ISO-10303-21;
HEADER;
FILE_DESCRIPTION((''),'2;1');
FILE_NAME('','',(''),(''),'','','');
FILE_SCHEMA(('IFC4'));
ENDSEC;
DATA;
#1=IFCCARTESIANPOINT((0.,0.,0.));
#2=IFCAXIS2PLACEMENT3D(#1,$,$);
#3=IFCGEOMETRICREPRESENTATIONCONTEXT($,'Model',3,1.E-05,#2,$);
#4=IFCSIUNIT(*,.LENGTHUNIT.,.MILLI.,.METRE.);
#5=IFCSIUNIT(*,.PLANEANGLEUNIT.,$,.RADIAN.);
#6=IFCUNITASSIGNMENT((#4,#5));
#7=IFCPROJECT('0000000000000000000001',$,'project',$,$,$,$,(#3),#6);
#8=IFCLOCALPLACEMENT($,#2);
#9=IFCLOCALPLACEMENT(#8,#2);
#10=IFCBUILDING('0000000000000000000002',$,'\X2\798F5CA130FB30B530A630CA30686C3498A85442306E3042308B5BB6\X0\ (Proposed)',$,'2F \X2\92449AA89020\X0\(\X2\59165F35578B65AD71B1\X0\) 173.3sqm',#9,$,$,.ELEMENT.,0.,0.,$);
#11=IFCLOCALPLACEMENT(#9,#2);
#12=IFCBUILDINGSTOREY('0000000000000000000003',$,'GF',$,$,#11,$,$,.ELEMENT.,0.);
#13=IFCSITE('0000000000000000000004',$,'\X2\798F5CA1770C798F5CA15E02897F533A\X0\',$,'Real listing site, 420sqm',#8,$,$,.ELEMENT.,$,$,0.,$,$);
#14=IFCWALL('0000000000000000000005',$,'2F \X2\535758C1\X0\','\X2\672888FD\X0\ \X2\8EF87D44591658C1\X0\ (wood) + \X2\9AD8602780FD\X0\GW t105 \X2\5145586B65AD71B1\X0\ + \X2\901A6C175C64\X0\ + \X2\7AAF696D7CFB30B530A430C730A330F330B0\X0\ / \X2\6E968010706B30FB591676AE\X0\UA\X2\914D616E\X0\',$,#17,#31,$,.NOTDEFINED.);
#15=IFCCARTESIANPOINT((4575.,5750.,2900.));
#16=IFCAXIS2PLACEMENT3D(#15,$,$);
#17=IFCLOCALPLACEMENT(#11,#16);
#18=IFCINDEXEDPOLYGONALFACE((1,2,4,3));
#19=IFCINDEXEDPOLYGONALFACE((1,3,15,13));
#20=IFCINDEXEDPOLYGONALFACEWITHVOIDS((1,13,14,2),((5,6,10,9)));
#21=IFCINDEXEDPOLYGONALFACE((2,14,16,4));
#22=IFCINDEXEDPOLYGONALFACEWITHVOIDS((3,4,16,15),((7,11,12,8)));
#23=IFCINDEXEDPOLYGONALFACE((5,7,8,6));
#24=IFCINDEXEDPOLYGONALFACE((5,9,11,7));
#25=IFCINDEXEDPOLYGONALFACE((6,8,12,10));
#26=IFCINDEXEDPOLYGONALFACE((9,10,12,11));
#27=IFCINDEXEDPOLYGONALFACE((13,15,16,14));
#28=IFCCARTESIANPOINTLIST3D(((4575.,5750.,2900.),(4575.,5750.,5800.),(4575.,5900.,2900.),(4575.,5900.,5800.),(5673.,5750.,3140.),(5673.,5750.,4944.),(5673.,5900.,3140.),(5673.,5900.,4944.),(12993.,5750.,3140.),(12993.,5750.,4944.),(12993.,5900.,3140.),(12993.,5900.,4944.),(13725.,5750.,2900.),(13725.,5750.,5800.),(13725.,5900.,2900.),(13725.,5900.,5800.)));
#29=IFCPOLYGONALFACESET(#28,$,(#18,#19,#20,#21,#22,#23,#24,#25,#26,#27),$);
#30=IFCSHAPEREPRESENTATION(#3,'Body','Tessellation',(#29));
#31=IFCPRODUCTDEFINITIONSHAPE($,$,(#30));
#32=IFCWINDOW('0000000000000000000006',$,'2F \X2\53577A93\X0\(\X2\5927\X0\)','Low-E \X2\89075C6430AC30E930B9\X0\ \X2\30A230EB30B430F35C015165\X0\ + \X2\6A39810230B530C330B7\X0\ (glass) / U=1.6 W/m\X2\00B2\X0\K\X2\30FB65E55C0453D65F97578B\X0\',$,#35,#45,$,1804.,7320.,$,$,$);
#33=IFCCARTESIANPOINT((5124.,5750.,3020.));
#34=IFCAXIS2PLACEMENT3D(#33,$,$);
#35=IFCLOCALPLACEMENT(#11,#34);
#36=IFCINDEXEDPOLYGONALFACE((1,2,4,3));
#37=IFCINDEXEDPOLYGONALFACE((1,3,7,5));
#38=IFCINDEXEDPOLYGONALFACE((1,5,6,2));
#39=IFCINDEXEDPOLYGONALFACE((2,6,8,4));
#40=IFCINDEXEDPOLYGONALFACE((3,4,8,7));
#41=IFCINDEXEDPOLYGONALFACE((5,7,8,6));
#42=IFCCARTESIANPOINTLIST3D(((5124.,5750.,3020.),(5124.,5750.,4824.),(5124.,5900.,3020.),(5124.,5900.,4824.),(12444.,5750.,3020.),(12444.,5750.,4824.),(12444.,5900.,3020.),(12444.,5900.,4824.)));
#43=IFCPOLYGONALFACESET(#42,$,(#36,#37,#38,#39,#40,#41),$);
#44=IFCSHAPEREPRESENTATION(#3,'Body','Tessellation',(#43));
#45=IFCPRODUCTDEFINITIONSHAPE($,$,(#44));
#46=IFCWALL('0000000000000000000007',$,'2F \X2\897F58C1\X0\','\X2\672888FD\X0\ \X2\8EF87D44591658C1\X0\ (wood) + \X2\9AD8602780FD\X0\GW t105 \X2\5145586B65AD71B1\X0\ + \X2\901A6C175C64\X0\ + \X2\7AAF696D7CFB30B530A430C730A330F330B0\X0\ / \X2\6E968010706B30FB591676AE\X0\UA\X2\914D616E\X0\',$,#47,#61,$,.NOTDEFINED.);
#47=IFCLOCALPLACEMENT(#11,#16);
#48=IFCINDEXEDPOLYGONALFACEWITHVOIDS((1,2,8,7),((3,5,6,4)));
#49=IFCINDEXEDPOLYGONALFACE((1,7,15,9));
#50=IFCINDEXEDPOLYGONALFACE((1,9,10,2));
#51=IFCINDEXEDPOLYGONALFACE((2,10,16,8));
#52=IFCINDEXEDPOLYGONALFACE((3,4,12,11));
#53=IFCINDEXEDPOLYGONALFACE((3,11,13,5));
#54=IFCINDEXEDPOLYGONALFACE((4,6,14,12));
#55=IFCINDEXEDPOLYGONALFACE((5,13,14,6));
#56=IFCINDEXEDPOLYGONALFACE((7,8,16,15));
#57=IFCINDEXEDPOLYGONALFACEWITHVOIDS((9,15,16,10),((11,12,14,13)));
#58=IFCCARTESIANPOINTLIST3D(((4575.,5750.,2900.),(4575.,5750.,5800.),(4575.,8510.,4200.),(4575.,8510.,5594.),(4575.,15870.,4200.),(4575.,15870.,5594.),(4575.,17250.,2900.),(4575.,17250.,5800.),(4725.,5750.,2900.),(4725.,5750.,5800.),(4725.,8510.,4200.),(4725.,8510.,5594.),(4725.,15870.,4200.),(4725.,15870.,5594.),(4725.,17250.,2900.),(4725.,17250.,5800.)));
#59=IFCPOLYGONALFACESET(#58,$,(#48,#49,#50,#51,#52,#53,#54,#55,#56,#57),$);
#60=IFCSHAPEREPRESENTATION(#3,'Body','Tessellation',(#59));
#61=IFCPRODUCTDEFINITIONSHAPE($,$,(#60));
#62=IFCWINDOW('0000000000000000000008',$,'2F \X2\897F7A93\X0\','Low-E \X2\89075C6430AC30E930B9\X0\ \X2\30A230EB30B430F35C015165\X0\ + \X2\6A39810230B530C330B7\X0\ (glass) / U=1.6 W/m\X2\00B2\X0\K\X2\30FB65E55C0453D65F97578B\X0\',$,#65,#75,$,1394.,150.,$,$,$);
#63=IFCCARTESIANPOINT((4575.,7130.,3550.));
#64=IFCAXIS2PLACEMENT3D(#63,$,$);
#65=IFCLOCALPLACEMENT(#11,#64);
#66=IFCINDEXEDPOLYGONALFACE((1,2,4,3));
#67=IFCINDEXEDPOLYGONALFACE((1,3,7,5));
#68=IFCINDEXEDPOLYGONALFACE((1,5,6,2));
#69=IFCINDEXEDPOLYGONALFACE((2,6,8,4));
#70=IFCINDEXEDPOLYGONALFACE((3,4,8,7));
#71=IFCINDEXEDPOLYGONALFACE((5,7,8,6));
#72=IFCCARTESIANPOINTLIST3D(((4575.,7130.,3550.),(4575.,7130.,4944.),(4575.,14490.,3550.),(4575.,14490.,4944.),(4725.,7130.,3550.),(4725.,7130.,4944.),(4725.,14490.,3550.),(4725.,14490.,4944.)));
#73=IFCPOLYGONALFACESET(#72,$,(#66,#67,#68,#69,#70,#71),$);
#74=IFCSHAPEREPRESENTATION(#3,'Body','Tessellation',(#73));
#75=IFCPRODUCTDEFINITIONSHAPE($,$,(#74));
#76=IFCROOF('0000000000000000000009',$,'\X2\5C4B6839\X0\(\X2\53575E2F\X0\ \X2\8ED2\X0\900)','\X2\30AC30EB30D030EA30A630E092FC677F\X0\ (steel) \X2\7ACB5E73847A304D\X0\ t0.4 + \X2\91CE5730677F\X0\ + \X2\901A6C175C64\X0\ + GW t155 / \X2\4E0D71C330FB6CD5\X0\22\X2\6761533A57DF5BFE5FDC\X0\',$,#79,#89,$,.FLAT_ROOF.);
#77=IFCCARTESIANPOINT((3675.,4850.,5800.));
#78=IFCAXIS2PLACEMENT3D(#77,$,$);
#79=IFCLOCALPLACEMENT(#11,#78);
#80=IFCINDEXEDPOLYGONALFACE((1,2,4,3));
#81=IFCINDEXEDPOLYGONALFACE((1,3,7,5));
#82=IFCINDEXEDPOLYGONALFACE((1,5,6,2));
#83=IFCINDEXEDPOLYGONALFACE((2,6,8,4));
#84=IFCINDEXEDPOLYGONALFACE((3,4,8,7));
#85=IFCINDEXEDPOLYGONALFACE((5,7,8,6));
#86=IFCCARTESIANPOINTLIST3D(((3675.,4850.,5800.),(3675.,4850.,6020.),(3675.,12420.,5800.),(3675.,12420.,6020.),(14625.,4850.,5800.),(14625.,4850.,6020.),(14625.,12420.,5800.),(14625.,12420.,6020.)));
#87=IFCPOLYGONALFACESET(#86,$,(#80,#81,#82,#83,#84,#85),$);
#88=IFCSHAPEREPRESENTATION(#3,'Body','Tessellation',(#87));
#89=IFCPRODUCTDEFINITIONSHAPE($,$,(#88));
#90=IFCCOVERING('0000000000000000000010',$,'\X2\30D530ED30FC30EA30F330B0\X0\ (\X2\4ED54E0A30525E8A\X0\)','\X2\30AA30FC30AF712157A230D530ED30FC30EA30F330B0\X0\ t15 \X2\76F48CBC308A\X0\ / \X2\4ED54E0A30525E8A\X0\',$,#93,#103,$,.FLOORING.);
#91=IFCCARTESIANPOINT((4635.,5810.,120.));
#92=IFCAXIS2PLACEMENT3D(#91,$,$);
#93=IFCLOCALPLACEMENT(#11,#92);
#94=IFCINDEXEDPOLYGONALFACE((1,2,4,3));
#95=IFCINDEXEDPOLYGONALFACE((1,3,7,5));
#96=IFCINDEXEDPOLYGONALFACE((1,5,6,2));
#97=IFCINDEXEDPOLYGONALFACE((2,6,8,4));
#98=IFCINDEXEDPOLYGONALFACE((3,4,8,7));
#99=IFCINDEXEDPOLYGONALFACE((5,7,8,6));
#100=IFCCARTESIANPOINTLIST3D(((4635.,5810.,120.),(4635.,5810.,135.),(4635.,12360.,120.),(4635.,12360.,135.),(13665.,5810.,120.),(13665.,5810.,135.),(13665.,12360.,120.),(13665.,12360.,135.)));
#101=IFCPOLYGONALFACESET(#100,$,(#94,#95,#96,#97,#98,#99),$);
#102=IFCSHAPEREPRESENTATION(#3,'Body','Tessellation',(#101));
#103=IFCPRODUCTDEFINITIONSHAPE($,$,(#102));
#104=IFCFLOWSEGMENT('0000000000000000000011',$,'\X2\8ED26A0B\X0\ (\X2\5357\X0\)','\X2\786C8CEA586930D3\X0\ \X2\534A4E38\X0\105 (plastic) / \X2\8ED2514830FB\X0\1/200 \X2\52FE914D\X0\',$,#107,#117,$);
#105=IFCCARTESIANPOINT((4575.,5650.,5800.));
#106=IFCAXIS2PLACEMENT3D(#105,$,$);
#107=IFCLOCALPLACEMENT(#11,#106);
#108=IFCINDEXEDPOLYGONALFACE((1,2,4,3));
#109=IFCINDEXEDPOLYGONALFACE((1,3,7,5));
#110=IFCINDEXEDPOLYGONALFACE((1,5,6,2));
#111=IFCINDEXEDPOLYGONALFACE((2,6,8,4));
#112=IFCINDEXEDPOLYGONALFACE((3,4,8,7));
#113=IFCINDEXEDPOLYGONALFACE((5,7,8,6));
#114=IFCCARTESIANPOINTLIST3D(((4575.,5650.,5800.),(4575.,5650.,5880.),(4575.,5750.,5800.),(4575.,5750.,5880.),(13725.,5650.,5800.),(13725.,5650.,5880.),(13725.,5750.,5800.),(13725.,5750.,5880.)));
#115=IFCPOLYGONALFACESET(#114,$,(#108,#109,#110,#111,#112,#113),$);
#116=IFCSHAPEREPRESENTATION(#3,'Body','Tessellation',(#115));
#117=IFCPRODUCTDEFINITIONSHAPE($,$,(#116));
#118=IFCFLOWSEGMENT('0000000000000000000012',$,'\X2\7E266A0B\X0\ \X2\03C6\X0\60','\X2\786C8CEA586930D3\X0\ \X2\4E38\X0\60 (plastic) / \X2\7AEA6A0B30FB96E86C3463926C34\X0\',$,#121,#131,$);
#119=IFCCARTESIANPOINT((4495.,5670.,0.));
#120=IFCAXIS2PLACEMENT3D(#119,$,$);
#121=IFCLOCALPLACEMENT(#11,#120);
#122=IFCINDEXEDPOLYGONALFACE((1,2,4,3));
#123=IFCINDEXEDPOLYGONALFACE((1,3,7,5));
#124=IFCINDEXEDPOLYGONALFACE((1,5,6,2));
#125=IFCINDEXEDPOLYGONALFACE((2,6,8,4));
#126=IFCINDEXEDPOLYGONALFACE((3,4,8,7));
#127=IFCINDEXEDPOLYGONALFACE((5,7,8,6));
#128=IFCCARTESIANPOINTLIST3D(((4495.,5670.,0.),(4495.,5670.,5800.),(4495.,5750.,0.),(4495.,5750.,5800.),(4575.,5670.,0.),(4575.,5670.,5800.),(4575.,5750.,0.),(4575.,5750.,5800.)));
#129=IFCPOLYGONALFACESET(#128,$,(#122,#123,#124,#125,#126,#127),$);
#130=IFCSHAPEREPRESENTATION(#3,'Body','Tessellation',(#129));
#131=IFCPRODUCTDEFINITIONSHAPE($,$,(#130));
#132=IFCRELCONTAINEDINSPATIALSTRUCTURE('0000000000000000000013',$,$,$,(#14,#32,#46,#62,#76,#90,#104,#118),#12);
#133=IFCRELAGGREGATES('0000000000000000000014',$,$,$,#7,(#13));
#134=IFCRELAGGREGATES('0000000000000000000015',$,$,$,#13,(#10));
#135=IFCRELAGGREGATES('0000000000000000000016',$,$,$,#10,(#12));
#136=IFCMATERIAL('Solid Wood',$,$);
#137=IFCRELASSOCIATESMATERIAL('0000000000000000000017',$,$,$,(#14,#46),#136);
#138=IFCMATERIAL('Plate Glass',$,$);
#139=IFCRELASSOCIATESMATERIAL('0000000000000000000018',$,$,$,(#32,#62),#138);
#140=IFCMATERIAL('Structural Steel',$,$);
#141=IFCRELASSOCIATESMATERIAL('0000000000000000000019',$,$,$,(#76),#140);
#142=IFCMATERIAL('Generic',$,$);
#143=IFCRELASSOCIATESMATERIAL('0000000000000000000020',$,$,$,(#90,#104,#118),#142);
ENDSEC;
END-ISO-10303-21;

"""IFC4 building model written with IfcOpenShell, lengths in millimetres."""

from ifc_helpers import new_model, si_unit, frame, frame_2d, origin, place, context, project, spatial, rectangle, extrude, material, element, fill, save


model = new_model("IFC4")

# Units and contexts
model_context = context("Model", 3, precision=1e-05, world=origin())
ifc_project = project(units=[si_unit("LENGTHUNIT", "METRE", prefix="MILLI"), si_unit("PLANEANGLEUNIT", "RADIAN")], contexts=[model_context])

# Site, building, storey
site_placement = place(None, origin())
site = spatial("IfcSite", under=ifc_project, at=site_placement, Name="福岡県福岡市西区", ObjectType="Real listing site, 420sqm", CompositionType="ELEMENT", RefElevation=0.0)
building_placement = place(site_placement, origin())
building = spatial("IfcBuilding", under=site, at=building_placement, Name="福岡・サウナと水風呂のある家 (Proposed)", ObjectType="2F 鉄骨造(外張型断熱) 173.3sqm", CompositionType="ELEMENT", ElevationOfRefHeight=0.0, ElevationOfTerrain=0.0)
storey_placement = place(building_placement, origin())
storey = spatial("IfcBuildingStorey", under=building, at=storey_placement, Name="GF", CompositionType="ELEMENT", Elevation=0.0)

# Shared definitions
ifc_material_1 = material(Name="Solid Wood")

# Shared definitions
ifc_material_2 = material(Name="Plate Glass")

# Walls, openings, windows
wall_1_placement = place(storey_placement, frame((4575.0, 5750.0, 2900.0)))
wall_1 = element("IfcWall", 1, at=wall_1_placement, inside=storey, material=ifc_material_1, Name="2F 南壁", Description="木製 軸組外壁 (wood) + 高性能GW t105 充填断熱 + 通気層 + 窯業系サイディング / 準耐火・外皮UA配慮", PredefinedType="NOTDEFINED", context=model_context, shape_type="SweptSolid", body=[
    extrude(rectangle(XDim=9150.0, YDim=150.0, at=frame_2d((4575.0, 75.0))), frame((4575.0, 5750.0, 2900.0)), (0.0, 0.0, 1.0), 2900.0),
])
opening_1_placement = place(storey_placement, frame((5124.0, 5750.0, 3020.0)))
opening_1 = element("IfcOpeningElement", 2, at=opening_1_placement, cuts=wall_1, PredefinedType="NOTDEFINED", context=model_context, shape_type="SweptSolid", body=[
    extrude(rectangle(XDim=7320.0, YDim=150.0, at=frame_2d((3660.0, 75.0))), frame((5124.0, 5750.0, 3020.0)), (0.0, 0.0, 1.0), 1804.0),
])
window_1_placement = place(storey_placement, frame((5124.0, 5750.0, 3020.0)))
window_1 = element("IfcWindow", 3, at=window_1_placement, inside=storey, material=ifc_material_2, Name="2F 南窓(大)", Description="Low-E 複層ガラス アルゴン封入 + 樹脂サッシ (glass) / U=1.6 W/m²K・日射取得型", OverallHeight=1804.0, OverallWidth=7320.0, context=model_context, shape_type="SweptSolid", body=[
    extrude(rectangle(XDim=7320.0, YDim=150.0, at=frame_2d((3660.0, 75.0))), frame((5124.0, 5750.0, 3020.0)), (0.0, 0.0, 1.0), 1804.0),
])
fill(opening_1, window_1)
wall_2_placement = place(storey_placement, frame((4575.0, 5750.0, 2900.0)))
wall_2 = element("IfcWall", 4, at=wall_2_placement, inside=storey, material=ifc_material_1, Name="2F 西壁", Description="木製 軸組外壁 (wood) + 高性能GW t105 充填断熱 + 通気層 + 窯業系サイディング / 準耐火・外皮UA配慮", PredefinedType="NOTDEFINED", context=model_context, shape_type="SweptSolid", body=[
    extrude(rectangle(XDim=150.0, YDim=11500.0, at=frame_2d((75.0, 5750.0))), frame((4575.0, 5750.0, 2900.0)), (0.0, 0.0, 1.0), 2900.0),
])
opening_2_placement = place(storey_placement, frame((4575.0, 7130.0, 3550.0)))
opening_2 = element("IfcOpeningElement", 5, at=opening_2_placement, cuts=wall_2, PredefinedType="NOTDEFINED", context=model_context, shape_type="SweptSolid", body=[
    extrude(rectangle(XDim=150.0, YDim=7360.0, at=frame_2d((75.0, 3680.0))), frame((4575.0, 7130.0, 3550.0)), (0.0, 0.0, 1.0), 1394.0),
])
window_2_placement = place(storey_placement, frame((4575.0, 7130.0, 3550.0)))
window_2 = element("IfcWindow", 6, at=window_2_placement, inside=storey, material=ifc_material_2, Name="2F 西窓", Description="Low-E 複層ガラス アルゴン封入 + 樹脂サッシ (glass) / U=1.6 W/m²K・日射取得型", OverallHeight=1394.0, OverallWidth=150.0, context=model_context, shape_type="SweptSolid", body=[
    extrude(rectangle(XDim=150.0, YDim=7360.0, at=frame_2d((75.0, 3680.0))), frame((4575.0, 7130.0, 3550.0)), (0.0, 0.0, 1.0), 1394.0),
])
fill(opening_2, window_2)

# Roof
ifc_material_3 = material(Name="Structural Steel")
for number, where, name in (
    (7, (3675.0, 4850.0, 5800.0), "屋根(南帯 軒900)"),
):
    element("IfcRoof", number, at=place(storey_placement, frame(where)), inside=storey, material=ifc_material_3, Name=name, Description="ガルバリウム鋼板 (steel) 立平葺き t0.4 + 野地板 + 通気層 + GW t155 / 不燃・法22条区域対応", PredefinedType="FLAT_ROOF", context=model_context, shape_type="SweptSolid", body=[
        extrude(rectangle(XDim=10950.0, YDim=7570.0, at=frame_2d((5475.0, 3785.0))), frame((3675.0, 4850.0, 5800.0)), (0.0, 0.0, 1.0), 220.0),
    ])

# Covering
ifc_material_4 = material(Name="Generic")
covering_placement = place(storey_placement, frame((4635.0, 5810.0, 120.0)))
element("IfcCovering", 8, at=covering_placement, inside=storey, material=ifc_material_4, Name="フローリング (仕上げ床)", Description="オーク無垢フローリング t15 直貼り / 仕上げ床", PredefinedType="FLOORING", context=model_context, shape_type="SweptSolid", body=[
    extrude(rectangle(XDim=9030.0, YDim=6550.0, at=frame_2d((4515.0, 3275.0))), frame((4635.0, 5810.0, 120.0)), (0.0, 0.0, 1.0), 15.0),
])

# Flow segments
flow_segment_1_placement = place(storey_placement, frame((4575.0, 5650.0, 5800.0)))
element("IfcFlowSegment", 9, at=flow_segment_1_placement, inside=storey, material=ifc_material_4, Name="軒樋 (南)", Description="硬質塩ビ 半丸105 (plastic) / 軒先・1/200 勾配", context=model_context, shape_type="SweptSolid", body=[
    extrude(rectangle(XDim=9150.0, YDim=100.0, at=frame_2d((4575.0, 50.0))), frame((4575.0, 5650.0, 5800.0)), (0.0, 0.0, 1.0), 80.0),
])
flow_segment_2_placement = place(storey_placement, frame((4495.0, 5670.0, 0.0)))
element("IfcFlowSegment", 10, at=flow_segment_2_placement, inside=storey, material=ifc_material_4, Name="縦樋 φ60", Description="硬質塩ビ 丸60 (plastic) / 竪樋・雨水排水", context=model_context, shape_type="SweptSolid", body=[
    extrude(rectangle(XDim=80.0, YDim=80.0, at=frame_2d((40.0, 40.0))), frame((4495.0, 5670.0, 0.0)), (0.0, 0.0, 1.0), 5800.0),
])

save(model, "model.ifc")
